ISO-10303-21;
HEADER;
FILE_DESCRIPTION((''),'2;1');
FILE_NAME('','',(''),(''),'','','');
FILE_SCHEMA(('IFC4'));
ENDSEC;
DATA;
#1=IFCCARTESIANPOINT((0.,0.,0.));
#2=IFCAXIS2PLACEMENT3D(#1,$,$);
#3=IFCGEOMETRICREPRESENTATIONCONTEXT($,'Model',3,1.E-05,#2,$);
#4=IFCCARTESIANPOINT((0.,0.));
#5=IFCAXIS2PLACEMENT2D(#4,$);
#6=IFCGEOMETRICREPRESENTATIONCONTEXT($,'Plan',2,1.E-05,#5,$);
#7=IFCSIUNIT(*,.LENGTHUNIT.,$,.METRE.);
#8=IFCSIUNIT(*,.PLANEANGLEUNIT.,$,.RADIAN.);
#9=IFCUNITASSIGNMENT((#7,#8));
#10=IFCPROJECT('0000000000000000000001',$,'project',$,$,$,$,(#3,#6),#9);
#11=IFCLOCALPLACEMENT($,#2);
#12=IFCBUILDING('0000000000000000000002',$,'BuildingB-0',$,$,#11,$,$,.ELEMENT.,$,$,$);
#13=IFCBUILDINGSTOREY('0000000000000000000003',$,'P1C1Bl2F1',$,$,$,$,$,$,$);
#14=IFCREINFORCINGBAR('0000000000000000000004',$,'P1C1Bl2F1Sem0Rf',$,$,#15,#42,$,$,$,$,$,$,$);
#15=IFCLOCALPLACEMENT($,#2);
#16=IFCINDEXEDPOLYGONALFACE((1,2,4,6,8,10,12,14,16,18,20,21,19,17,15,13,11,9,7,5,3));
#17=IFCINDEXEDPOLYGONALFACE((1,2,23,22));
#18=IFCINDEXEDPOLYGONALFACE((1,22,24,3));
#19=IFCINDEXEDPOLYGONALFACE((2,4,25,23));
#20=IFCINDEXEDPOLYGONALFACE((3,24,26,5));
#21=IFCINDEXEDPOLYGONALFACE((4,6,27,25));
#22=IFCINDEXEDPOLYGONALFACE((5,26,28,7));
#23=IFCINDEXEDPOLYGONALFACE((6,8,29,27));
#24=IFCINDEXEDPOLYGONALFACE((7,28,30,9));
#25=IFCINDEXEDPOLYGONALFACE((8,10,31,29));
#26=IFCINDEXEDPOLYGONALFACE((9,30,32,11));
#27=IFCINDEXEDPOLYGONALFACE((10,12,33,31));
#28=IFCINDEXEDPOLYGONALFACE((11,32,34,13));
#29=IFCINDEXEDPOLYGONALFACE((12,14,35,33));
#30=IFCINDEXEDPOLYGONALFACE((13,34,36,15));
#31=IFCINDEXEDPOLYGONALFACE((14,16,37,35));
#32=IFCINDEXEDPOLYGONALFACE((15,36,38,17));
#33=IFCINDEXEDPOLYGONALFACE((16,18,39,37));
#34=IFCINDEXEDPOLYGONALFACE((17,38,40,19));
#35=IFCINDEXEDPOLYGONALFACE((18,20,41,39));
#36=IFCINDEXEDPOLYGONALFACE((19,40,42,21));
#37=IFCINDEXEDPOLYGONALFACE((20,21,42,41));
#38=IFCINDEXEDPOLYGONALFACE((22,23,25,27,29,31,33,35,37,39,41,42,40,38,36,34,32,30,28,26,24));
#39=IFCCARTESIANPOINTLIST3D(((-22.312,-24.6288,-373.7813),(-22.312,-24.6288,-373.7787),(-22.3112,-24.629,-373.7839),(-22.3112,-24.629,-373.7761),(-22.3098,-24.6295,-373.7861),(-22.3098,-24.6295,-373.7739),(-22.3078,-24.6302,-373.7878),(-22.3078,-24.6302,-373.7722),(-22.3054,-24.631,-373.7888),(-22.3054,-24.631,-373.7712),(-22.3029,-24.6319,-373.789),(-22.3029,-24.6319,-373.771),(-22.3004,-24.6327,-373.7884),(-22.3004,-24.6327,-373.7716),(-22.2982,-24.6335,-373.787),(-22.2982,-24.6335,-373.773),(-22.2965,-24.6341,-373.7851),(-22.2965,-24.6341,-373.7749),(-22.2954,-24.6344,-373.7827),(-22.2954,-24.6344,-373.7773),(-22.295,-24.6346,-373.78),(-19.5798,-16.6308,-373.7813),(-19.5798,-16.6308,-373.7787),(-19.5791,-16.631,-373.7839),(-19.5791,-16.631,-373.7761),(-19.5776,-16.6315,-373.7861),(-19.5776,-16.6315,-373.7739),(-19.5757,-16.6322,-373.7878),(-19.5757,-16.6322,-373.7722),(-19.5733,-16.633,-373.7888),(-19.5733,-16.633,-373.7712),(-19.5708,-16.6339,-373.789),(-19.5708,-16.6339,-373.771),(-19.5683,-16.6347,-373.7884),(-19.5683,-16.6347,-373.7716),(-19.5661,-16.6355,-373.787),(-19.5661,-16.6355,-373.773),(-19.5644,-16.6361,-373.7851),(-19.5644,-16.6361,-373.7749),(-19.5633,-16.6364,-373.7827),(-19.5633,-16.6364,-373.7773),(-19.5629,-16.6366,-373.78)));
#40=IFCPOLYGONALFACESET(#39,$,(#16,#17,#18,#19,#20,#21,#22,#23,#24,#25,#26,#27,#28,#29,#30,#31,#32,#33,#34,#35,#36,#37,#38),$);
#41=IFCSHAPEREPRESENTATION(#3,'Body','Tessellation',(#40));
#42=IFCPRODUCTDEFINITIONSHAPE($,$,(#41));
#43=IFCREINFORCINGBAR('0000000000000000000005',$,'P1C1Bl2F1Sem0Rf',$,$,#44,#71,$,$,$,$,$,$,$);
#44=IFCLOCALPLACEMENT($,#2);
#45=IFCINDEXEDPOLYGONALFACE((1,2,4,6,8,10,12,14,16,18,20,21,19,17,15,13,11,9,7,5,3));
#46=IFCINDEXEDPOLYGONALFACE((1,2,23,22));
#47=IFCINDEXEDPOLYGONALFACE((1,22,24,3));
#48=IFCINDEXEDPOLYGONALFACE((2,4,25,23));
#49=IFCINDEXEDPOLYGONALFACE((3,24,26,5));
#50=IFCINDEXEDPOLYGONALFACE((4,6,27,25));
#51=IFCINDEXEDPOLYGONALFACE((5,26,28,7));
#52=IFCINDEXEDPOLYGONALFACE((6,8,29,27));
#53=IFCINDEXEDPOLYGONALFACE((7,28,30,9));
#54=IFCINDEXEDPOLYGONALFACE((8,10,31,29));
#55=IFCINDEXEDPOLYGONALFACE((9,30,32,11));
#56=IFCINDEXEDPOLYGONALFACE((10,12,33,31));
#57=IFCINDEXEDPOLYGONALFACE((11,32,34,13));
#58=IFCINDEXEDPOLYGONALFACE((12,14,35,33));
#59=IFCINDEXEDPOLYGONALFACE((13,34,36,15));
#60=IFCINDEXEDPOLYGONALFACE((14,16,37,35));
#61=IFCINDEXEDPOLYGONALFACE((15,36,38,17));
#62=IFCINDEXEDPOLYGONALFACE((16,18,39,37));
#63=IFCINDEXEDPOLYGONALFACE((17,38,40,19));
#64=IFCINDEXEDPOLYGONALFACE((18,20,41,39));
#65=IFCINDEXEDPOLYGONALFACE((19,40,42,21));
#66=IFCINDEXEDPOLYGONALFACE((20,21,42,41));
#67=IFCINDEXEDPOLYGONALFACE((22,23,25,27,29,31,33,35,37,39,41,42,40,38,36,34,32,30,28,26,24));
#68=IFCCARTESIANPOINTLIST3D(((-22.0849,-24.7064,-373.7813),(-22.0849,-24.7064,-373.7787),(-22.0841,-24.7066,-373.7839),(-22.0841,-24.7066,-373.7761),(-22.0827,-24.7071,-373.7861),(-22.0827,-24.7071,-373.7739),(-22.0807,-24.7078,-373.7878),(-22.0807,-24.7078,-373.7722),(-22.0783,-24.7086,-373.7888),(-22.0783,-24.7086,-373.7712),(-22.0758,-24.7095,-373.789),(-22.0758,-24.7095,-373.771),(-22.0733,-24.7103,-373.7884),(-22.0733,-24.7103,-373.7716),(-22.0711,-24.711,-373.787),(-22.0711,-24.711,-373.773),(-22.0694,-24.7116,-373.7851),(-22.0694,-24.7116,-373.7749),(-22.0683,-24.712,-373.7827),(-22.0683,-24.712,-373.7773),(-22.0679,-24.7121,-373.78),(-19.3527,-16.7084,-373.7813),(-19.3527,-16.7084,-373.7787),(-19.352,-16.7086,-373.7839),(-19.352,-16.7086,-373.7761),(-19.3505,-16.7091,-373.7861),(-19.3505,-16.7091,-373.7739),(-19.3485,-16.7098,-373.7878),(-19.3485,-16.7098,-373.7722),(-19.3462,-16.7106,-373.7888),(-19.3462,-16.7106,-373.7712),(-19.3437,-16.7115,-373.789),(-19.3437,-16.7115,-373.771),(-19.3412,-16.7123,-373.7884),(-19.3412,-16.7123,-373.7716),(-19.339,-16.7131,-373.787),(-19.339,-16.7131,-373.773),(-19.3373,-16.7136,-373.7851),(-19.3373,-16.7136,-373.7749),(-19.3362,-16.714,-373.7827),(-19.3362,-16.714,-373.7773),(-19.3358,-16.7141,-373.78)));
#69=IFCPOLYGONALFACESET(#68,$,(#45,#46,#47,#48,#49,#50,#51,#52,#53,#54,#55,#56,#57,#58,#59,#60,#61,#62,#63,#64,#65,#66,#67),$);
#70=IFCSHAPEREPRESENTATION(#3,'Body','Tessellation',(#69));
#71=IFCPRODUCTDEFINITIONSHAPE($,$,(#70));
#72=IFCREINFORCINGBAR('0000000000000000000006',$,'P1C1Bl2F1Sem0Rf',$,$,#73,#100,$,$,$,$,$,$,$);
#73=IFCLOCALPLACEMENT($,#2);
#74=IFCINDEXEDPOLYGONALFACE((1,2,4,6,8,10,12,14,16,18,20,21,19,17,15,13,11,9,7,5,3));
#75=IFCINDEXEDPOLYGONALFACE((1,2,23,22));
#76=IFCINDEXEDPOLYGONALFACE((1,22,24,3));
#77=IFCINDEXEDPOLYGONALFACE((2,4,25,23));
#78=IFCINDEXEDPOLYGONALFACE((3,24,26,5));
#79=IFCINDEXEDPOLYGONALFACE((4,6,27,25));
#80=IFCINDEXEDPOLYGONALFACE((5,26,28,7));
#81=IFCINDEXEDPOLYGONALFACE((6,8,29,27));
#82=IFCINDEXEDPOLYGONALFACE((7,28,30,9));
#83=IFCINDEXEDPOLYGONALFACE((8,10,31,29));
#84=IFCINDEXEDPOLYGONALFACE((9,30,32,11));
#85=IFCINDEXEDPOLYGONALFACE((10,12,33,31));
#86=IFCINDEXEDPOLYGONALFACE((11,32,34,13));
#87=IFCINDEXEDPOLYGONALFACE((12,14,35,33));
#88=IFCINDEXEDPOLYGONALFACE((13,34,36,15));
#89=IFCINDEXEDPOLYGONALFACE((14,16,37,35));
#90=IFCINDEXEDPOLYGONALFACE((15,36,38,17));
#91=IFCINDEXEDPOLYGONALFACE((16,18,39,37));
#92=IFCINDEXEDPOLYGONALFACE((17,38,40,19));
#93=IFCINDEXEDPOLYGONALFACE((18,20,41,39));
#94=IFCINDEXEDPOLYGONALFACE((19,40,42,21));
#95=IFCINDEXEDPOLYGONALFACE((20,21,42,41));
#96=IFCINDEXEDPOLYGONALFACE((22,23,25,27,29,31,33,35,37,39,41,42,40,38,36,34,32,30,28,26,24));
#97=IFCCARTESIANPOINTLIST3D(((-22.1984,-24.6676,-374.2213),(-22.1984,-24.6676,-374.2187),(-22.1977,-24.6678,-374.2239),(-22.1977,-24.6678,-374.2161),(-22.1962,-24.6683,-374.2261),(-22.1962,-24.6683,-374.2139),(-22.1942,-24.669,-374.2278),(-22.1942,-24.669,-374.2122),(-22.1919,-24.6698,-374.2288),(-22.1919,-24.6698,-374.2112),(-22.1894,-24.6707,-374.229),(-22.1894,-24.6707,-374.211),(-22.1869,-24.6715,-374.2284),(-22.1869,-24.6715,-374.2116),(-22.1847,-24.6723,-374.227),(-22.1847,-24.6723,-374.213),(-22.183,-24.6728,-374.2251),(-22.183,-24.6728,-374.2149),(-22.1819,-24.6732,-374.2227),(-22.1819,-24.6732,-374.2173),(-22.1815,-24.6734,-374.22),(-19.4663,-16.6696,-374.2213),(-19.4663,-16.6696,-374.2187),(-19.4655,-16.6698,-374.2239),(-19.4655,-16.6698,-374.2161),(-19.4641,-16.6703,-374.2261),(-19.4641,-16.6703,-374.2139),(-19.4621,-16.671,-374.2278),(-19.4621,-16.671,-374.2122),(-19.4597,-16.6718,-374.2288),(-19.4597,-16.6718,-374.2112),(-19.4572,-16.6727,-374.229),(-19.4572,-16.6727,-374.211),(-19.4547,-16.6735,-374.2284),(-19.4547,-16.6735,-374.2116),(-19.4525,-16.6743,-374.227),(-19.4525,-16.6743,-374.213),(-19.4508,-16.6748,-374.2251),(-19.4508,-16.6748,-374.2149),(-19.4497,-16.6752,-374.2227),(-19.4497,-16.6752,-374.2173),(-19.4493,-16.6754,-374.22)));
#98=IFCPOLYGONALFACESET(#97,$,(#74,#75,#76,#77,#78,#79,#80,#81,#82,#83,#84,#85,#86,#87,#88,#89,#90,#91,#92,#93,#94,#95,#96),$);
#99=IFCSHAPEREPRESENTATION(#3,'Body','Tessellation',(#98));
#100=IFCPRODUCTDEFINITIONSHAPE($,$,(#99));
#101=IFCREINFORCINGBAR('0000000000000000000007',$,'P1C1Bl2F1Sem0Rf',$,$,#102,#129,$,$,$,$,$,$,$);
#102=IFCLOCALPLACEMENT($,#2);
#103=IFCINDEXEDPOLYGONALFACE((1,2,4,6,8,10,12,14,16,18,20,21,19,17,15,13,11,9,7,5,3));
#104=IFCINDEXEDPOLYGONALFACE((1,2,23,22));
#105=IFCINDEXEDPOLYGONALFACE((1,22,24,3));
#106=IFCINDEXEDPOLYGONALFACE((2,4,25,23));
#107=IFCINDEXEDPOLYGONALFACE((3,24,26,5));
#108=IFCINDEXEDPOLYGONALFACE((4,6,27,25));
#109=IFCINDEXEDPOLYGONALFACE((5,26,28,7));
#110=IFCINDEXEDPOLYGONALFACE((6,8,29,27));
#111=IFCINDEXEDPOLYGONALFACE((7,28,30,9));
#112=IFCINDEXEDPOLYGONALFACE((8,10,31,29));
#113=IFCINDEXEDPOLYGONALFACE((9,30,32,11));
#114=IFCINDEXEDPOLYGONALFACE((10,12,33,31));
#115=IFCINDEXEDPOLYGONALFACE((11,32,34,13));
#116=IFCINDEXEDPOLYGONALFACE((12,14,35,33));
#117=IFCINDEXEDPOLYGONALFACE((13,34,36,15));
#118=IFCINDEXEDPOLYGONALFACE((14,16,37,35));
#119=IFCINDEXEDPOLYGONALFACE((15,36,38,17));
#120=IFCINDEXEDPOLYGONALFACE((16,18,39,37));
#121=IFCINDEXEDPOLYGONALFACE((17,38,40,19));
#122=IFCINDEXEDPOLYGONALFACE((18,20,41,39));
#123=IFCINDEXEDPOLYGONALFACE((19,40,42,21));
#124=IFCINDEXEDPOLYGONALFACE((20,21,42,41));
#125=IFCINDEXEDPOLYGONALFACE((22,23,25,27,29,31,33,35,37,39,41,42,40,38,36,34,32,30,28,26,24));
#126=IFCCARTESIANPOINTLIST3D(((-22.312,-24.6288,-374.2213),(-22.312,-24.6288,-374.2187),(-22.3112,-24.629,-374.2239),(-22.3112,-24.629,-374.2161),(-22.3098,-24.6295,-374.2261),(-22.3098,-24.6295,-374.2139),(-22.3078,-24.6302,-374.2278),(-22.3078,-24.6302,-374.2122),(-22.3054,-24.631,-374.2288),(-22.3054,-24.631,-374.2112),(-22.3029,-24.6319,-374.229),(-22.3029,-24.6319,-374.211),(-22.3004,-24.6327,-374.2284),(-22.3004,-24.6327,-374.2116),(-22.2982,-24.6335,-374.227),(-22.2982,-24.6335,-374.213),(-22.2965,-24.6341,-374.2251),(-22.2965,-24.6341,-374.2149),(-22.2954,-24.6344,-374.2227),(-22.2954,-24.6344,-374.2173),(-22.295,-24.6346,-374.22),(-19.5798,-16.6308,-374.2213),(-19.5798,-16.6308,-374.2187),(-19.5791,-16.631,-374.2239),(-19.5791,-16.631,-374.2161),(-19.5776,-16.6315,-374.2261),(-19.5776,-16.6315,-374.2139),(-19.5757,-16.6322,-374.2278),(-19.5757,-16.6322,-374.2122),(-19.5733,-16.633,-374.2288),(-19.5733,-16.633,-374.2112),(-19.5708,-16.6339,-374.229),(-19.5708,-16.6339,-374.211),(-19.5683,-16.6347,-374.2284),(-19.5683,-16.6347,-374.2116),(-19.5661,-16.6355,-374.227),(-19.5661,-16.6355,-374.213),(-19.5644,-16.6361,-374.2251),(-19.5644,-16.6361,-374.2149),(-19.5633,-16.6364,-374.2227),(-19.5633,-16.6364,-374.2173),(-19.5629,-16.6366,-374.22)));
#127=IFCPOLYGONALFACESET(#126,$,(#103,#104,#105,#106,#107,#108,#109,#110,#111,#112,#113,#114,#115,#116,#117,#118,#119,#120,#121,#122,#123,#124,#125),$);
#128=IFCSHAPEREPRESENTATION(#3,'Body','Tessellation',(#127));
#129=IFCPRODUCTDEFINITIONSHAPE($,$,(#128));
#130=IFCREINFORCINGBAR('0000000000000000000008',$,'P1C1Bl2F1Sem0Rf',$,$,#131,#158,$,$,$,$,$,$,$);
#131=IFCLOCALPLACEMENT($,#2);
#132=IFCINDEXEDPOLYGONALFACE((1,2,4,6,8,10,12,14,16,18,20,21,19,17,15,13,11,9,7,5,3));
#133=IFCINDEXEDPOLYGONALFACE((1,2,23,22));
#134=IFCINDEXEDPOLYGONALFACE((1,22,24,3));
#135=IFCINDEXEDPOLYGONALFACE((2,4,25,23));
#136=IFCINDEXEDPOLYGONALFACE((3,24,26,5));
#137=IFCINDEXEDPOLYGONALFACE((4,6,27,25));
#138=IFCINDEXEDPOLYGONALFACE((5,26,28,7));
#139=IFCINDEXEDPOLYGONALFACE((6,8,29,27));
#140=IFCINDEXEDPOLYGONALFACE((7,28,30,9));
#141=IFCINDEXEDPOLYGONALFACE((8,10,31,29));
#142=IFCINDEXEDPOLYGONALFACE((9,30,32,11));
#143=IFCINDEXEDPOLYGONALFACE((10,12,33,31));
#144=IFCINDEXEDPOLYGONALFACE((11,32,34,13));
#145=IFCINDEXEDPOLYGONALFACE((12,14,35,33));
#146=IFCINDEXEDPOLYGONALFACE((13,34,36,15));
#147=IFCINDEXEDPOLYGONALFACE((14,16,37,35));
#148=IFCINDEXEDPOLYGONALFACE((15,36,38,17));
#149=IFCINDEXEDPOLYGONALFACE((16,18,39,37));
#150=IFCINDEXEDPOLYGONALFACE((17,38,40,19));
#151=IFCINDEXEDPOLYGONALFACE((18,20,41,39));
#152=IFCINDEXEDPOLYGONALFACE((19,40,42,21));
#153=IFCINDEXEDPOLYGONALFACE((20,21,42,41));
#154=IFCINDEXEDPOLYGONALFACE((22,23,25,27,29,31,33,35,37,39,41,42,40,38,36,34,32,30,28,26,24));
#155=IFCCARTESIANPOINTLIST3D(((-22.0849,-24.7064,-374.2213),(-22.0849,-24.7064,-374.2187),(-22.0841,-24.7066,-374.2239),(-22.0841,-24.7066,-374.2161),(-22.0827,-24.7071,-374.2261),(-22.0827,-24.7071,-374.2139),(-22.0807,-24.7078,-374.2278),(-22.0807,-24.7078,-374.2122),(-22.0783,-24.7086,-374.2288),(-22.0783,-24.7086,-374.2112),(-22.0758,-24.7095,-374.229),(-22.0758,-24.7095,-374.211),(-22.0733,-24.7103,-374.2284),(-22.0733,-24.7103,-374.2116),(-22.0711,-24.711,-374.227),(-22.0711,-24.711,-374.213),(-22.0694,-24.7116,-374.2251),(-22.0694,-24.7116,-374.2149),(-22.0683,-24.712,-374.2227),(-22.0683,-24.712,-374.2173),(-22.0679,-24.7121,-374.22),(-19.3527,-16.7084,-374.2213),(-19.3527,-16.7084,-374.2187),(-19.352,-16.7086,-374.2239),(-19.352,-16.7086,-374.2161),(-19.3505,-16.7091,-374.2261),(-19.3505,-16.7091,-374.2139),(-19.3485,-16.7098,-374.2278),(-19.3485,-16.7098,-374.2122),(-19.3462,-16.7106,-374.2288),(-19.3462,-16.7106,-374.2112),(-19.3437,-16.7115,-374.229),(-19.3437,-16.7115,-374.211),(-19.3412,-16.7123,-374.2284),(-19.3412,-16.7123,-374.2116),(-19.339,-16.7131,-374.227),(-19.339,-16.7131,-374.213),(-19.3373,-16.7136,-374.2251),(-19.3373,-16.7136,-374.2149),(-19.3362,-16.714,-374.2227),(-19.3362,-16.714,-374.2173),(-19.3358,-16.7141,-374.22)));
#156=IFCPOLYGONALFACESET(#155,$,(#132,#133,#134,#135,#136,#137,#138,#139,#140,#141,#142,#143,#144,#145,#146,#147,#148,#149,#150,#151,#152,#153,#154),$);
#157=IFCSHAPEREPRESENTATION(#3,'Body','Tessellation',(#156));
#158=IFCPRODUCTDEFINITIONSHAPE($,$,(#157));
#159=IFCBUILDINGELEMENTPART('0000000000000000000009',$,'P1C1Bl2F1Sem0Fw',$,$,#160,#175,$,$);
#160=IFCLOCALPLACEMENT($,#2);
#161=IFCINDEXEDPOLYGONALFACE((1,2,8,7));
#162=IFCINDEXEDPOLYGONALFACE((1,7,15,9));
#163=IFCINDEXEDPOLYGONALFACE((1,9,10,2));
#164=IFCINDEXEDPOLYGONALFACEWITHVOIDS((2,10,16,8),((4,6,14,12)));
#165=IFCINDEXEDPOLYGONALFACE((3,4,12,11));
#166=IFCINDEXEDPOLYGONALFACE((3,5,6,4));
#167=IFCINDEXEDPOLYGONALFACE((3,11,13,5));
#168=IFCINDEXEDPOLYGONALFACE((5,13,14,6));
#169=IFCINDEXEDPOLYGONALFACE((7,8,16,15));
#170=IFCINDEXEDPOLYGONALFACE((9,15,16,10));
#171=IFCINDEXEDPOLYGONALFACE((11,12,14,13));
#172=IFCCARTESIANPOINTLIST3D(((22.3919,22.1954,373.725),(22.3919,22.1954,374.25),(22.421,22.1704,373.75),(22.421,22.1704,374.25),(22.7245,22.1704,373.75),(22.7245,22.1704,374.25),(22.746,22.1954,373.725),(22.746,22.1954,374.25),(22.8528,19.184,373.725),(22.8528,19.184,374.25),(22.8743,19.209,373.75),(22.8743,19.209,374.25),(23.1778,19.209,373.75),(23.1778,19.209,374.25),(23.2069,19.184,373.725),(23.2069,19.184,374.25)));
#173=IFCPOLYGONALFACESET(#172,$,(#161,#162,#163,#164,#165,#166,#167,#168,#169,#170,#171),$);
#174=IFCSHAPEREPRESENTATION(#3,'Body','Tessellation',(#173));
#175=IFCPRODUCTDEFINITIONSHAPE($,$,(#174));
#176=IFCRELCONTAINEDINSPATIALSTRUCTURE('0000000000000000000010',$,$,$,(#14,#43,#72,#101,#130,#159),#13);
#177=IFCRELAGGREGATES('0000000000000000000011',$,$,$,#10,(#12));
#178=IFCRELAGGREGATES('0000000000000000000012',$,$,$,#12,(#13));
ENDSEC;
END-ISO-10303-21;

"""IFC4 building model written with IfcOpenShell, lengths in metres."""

from ifc_helpers import new_model, entity, si_unit, origin, origin_2d, place, context, project, spatial, polyline, outline, extrude, element, save


model = new_model("IFC4")

# Units and contexts
model_context = context("Model", 3, precision=1e-05, world=origin())
plan_context = context("Plan", 2, precision=1e-05, world=origin_2d())
ifc_project = project(units=[si_unit("LENGTHUNIT", "METRE"), si_unit("PLANEANGLEUNIT", "RADIAN")], contexts=[model_context, plan_context])

# Building, storey
building_placement = place(None, origin())
building = spatial("IfcBuilding", under=ifc_project, at=building_placement, Name="BuildingB-0", CompositionType="ELEMENT")
storey = spatial("IfcBuildingStorey", under=building, Name="P1C1Bl2F1")

# Reinforcing bars
element("IfcReinforcingBar", 1, inside=storey, Name="P1C1Bl2F1Sem0Rf", context=model_context, shape_type="SweptSolid", body=[
    entity("IfcSurfaceCurveSweptAreaSolid", entity("IfcCircleProfileDef", "AREA", None, None, 0.009), None, entity("IfcPolyline", [entity("IfcCartesianPoint", [19.5714, 16.6337, 373.78]), entity("IfcCartesianPoint", [22.3035, 24.6317, 373.78])]), None, None, entity("IfcPlane", entity("IfcAxis2Placement3D", entity("IfcCartesianPoint", [19.5714, 16.6337, 373.78]), entity("IfcDirection", [0.0, 0.0, 1.0]), entity("IfcDirection", [1.0, 0.0, 0.0])))),
])
element("IfcReinforcingBar", 2, inside=storey, Name="P1C1Bl2F1Sem0Rf", context=model_context, shape_type="SweptSolid", body=[
    entity("IfcSurfaceCurveSweptAreaSolid", entity("IfcCircleProfileDef", "AREA", None, None, 0.009), None, entity("IfcPolyline", [entity("IfcCartesianPoint", [19.3443, 16.7112, 373.78]), entity("IfcCartesianPoint", [22.0764, 24.7092, 373.78])]), None, None, entity("IfcPlane", entity("IfcAxis2Placement3D", entity("IfcCartesianPoint", [19.3443, 16.7112, 373.78]), entity("IfcDirection", [0.0, 0.0, 1.0]), entity("IfcDirection", [1.0, 0.0, 0.0])))),
])
element("IfcReinforcingBar", 3, inside=storey, Name="P1C1Bl2F1Sem0Rf", context=model_context, shape_type="SweptSolid", body=[
    entity("IfcSurfaceCurveSweptAreaSolid", entity("IfcCircleProfileDef", "AREA", None, None, 0.009), None, entity("IfcPolyline", [entity("IfcCartesianPoint", [19.4578, 16.6724, 374.22]), entity("IfcCartesianPoint", [22.19, 24.6704, 374.22])]), None, None, entity("IfcPlane", entity("IfcAxis2Placement3D", entity("IfcCartesianPoint", [19.4578, 16.6724, 374.22]), entity("IfcDirection", [0.0, 0.0, 1.0]), entity("IfcDirection", [1.0, 0.0, 0.0])))),
])
element("IfcReinforcingBar", 4, inside=storey, Name="P1C1Bl2F1Sem0Rf", context=model_context, shape_type="SweptSolid", body=[
    entity("IfcSurfaceCurveSweptAreaSolid", entity("IfcCircleProfileDef", "AREA", None, None, 0.009), None, entity("IfcPolyline", [entity("IfcCartesianPoint", [19.5714, 16.6337, 374.22]), entity("IfcCartesianPoint", [22.3035, 24.6317, 374.22])]), None, None, entity("IfcPlane", entity("IfcAxis2Placement3D", entity("IfcCartesianPoint", [19.5714, 16.6337, 374.22]), entity("IfcDirection", [0.0, 0.0, 1.0]), entity("IfcDirection", [1.0, 0.0, 0.0])))),
])
element("IfcReinforcingBar", 5, inside=storey, Name="P1C1Bl2F1Sem0Rf", context=model_context, shape_type="SweptSolid", body=[
    entity("IfcSurfaceCurveSweptAreaSolid", entity("IfcCircleProfileDef", "AREA", None, None, 0.009), None, entity("IfcPolyline", [entity("IfcCartesianPoint", [19.3443, 16.7112, 374.22]), entity("IfcCartesianPoint", [22.0764, 24.7092, 374.22])]), None, None, entity("IfcPlane", entity("IfcAxis2Placement3D", entity("IfcCartesianPoint", [19.3443, 16.7112, 374.22]), entity("IfcDirection", [0.0, 0.0, 1.0]), entity("IfcDirection", [1.0, 0.0, 0.0])))),
])

# Building element part, opening
building_element_part_1 = element("IfcBuildingElementPart", 6, inside=storey, Name="P1C1Bl2F1Sem0Fw", context=model_context, shape_type="SweptSolid", body=[
    extrude(outline(polyline([(22.8528, 19.184, 373.725), (23.2069, 19.184, 373.725), (22.746, 22.1954, 373.725), (22.3919, 22.1954, 373.725), (22.8528, 19.184, 373.725)])), None, (0.0, 0.0, 1.0), 0.525),
])
element("IfcOpeningElement", 7, inside=storey, cuts=building_element_part_1, context=model_context, shape_type="SweptSolid", body=[
    extrude(outline(polyline([(22.8743, 19.209, 373.75), (23.1778, 19.209, 373.75), (22.7245, 22.1704, 373.75), (22.421, 22.1704, 373.75), (22.8743, 19.209, 373.75)])), None, (0.0, 0.0, 1.0), 0.5),
])

save(model, "model.ifc")
